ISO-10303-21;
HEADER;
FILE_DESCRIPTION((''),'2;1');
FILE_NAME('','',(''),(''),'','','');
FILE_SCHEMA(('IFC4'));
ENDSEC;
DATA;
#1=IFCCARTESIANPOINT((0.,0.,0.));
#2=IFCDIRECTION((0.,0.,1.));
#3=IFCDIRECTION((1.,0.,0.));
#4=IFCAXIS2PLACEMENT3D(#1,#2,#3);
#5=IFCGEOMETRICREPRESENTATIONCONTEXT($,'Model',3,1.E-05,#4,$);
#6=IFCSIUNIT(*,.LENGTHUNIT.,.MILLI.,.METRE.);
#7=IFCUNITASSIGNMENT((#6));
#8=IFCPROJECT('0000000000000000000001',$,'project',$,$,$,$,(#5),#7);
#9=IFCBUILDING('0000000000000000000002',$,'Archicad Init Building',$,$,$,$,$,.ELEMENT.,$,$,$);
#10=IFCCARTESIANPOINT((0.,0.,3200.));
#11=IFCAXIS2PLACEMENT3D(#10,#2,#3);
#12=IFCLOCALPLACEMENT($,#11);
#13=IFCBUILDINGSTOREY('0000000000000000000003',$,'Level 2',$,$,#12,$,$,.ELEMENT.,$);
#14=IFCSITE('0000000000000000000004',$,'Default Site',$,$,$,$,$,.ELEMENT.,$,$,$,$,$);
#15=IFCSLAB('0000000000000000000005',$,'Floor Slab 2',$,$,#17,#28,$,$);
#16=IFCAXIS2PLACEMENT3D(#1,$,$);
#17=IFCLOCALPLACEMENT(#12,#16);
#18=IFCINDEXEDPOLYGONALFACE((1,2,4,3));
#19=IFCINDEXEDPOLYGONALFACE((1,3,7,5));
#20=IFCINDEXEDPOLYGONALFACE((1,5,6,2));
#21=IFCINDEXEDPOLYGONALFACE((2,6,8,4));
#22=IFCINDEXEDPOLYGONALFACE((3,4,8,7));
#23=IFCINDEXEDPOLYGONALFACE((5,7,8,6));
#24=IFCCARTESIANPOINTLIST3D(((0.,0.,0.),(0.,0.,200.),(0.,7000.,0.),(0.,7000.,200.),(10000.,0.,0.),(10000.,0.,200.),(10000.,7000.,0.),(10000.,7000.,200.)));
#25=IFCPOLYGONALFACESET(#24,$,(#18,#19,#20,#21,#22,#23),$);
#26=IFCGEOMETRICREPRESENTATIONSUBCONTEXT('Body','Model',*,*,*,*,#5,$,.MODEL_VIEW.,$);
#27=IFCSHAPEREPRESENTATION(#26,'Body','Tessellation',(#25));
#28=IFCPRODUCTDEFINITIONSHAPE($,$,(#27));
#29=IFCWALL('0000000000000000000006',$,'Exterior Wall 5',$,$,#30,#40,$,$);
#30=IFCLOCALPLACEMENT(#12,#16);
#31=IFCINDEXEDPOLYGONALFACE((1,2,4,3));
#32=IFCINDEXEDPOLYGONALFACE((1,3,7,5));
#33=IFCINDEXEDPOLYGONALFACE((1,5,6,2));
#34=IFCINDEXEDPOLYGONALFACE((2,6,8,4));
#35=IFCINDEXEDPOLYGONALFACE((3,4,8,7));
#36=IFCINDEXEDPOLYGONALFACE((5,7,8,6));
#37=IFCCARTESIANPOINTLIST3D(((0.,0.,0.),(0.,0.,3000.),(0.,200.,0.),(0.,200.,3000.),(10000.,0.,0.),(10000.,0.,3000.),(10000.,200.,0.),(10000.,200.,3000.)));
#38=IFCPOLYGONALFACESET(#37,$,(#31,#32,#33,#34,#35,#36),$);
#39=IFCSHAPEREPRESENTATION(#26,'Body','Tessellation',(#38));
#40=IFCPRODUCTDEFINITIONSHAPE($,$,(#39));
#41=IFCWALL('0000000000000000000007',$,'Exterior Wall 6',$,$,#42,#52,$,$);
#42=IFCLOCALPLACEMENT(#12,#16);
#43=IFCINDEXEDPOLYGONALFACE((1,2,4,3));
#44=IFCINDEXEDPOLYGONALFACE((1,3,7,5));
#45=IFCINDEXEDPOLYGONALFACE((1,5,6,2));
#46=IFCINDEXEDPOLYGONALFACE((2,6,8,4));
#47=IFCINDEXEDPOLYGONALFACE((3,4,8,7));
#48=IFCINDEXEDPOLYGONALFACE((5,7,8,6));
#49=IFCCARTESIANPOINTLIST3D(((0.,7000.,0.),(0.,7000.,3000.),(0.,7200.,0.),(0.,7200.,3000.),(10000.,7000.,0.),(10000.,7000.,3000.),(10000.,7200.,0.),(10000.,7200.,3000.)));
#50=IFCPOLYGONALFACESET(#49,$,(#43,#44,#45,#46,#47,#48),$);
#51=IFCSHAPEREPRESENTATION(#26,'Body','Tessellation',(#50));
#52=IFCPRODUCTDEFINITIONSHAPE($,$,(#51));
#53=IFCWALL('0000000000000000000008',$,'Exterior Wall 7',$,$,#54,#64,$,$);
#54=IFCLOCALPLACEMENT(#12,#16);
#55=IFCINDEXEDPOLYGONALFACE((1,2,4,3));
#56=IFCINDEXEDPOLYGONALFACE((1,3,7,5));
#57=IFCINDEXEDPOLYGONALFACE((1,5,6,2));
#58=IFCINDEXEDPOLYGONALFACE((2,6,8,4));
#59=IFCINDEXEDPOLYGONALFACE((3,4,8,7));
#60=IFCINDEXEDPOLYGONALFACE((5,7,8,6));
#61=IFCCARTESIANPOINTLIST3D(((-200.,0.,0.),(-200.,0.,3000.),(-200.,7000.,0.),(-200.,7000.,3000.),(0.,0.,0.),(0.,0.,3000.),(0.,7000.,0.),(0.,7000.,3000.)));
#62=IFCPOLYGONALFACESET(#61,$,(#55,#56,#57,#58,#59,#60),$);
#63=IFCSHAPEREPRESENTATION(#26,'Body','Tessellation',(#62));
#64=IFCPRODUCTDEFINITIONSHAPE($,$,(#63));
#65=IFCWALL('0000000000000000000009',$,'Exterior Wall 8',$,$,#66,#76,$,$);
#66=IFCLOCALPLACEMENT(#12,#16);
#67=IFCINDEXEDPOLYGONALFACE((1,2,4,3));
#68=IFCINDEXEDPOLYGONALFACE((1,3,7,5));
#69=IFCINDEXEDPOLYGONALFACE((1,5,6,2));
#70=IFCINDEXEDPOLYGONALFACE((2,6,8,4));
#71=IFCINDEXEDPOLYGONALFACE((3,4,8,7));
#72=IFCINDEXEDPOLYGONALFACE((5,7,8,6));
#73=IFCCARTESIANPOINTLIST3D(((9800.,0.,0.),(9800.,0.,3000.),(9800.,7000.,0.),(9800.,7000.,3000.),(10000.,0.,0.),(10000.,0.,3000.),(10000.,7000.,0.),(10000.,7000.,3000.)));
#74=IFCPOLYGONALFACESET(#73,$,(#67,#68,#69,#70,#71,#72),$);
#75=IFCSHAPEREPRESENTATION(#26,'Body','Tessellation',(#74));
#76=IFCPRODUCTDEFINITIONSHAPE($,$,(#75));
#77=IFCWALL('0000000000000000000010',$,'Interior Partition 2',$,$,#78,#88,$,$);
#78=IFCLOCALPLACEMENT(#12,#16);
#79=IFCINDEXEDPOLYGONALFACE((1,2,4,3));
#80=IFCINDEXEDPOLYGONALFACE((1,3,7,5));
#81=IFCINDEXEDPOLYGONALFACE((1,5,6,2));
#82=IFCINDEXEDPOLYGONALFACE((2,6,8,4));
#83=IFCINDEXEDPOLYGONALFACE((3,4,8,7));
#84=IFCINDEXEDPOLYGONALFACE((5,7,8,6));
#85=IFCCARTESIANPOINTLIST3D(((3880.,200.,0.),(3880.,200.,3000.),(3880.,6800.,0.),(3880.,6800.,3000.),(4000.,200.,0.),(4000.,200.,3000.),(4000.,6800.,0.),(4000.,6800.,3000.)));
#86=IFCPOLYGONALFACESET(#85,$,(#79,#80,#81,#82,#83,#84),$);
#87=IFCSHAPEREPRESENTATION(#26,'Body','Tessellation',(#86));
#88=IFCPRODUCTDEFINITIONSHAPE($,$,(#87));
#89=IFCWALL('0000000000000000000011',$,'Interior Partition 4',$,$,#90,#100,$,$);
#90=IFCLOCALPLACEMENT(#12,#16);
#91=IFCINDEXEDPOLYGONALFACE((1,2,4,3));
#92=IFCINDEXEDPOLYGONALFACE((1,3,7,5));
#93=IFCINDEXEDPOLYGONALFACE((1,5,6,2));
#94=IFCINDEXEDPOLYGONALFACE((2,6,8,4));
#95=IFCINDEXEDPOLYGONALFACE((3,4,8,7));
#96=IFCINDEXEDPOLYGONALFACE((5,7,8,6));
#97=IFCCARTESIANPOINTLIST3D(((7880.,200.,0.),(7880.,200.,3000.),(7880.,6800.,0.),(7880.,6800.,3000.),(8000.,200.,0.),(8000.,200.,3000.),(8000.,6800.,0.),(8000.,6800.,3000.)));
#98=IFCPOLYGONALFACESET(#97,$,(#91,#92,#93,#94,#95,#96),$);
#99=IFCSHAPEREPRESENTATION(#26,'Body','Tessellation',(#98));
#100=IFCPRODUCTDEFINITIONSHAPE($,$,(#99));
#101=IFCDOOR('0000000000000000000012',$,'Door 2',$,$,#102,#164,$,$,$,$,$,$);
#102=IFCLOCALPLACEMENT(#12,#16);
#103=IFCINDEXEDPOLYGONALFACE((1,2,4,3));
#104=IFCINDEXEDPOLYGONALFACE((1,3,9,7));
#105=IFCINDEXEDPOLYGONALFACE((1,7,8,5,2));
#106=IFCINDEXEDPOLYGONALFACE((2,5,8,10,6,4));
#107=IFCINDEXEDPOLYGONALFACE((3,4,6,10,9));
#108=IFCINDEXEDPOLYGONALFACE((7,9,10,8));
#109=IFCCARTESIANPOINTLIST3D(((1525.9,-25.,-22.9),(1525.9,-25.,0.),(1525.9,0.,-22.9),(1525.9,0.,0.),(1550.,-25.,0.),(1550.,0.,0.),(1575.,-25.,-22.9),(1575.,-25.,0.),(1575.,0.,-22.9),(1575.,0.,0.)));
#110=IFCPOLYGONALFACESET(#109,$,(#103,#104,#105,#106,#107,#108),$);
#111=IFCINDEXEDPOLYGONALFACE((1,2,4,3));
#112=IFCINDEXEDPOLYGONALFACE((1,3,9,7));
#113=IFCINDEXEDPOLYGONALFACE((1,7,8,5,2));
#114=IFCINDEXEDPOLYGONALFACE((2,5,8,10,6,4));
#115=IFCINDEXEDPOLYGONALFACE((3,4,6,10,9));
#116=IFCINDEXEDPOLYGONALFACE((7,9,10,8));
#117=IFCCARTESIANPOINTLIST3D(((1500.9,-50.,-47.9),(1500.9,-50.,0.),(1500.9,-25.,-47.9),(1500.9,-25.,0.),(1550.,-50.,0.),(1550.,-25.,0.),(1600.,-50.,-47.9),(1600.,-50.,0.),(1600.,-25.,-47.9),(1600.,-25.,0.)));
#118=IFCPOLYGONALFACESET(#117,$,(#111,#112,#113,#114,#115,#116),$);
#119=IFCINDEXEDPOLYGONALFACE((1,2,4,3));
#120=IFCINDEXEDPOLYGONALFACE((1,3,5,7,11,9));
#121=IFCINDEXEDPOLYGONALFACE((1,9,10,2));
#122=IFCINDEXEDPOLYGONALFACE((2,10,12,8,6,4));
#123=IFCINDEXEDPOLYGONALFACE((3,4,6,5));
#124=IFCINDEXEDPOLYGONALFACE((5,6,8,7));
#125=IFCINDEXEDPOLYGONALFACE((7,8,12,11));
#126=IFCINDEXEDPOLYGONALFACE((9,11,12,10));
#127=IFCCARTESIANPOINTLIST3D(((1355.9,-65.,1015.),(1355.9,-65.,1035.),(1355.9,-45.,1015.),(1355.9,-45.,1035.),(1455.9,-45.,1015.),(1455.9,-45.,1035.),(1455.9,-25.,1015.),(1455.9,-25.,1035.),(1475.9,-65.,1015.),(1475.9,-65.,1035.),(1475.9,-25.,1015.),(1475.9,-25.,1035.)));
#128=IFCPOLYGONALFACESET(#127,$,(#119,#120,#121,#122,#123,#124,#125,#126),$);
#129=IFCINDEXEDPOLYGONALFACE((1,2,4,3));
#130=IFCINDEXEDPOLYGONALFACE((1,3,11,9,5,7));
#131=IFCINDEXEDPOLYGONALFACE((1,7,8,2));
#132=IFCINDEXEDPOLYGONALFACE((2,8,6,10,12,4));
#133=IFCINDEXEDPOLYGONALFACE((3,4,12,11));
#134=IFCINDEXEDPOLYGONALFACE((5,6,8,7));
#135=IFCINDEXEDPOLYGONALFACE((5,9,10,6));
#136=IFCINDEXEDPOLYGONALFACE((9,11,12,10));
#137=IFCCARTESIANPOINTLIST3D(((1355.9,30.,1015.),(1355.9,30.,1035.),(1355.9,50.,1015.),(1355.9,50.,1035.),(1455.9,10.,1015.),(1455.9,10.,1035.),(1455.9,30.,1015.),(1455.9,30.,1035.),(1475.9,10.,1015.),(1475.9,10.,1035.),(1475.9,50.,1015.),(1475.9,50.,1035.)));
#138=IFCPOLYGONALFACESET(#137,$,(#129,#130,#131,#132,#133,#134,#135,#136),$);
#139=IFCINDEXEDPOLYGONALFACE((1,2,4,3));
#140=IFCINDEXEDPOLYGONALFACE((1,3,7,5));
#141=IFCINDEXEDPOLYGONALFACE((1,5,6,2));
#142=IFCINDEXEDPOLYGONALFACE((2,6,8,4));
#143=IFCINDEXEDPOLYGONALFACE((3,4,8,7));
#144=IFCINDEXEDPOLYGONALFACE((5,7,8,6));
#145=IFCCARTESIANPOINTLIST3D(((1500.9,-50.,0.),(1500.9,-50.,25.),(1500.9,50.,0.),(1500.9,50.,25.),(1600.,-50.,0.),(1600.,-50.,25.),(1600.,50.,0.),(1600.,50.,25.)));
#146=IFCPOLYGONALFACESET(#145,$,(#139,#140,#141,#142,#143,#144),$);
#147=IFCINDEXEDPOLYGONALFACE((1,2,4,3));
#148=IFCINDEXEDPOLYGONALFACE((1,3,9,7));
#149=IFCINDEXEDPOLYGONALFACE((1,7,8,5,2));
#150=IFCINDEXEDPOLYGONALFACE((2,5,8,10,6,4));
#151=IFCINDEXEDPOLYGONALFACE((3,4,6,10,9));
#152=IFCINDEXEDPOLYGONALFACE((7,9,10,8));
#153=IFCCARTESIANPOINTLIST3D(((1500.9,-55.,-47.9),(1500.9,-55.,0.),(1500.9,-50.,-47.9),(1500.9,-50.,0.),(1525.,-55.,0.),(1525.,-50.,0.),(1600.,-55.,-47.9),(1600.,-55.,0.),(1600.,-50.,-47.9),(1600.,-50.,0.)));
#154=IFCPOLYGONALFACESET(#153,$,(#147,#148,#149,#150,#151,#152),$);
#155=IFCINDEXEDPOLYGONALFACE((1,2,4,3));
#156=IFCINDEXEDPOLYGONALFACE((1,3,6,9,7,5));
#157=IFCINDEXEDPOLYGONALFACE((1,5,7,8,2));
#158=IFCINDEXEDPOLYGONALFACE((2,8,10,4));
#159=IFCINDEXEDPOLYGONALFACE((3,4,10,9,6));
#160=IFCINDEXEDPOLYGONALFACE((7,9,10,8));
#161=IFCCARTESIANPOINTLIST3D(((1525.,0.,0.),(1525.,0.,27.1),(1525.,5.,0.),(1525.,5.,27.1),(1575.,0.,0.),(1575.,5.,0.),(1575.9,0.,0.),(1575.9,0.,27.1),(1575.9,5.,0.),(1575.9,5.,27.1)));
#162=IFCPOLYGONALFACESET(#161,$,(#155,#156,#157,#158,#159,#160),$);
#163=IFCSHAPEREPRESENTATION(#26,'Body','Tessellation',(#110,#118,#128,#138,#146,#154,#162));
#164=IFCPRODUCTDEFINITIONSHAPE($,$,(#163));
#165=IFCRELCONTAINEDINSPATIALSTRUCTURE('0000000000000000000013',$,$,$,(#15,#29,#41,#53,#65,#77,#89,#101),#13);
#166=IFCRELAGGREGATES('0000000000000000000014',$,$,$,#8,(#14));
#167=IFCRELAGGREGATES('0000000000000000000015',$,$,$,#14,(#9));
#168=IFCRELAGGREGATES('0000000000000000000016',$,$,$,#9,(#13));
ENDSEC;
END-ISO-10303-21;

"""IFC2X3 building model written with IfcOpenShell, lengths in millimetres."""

from ifc_helpers import new_model, si_unit, frame, origin_with_axes, place, context, subcontext, project, spatial, polyline, outline, extrude, element, save


model = new_model("IFC2X3")

# Units and contexts
model_context = context("Model", 3, precision=1e-05, world=origin_with_axes())
body_context = subcontext(model_context, "Body", "Model", "MODEL_VIEW")
ifc_project = project(units=[si_unit("LENGTHUNIT", "METRE", prefix="MILLI")], contexts=[model_context])

# Site, building, storey
site = spatial("IfcSite", under=ifc_project, Name="Default Site", CompositionType="ELEMENT")
building = spatial("IfcBuilding", under=site, Name="Archicad Init Building", CompositionType="ELEMENT")
storey_placement = place(None, frame((0.0, 0.0, 3200.0), z_axis=(0.0, 0.0, 1.0), x_axis=(1.0, 0.0, 0.0)))
storey = spatial("IfcBuildingStorey", under=building, at=storey_placement, Name="Level 2", CompositionType="ELEMENT")

# Slab
slab_placement = place(storey_placement, origin_with_axes())
element("IfcSlab", 1, at=slab_placement, inside=storey, Name="Floor Slab 2", context=body_context, shape_type="SweptSolid", body=[
    extrude(outline(polyline([(0.0, 0.0), (10000.0, 0.0), (10000.0, 7000.0), (0.0, 7000.0), (0.0, 0.0)])), origin_with_axes(), (0.0, 0.0, 1.0), 200.0),
])

# Walls
for number, where, z_axis, x_axis, name in (
    (2, (0.0, 0.0, 0.0), (0.0, 0.0, 1.0), (1.0, 0.0, 0.0), "Exterior Wall 5"),
    (3, (0.0, 7000.0, 0.0), (0.0, 0.0, 1.0), (1.0, 0.0, 0.0), "Exterior Wall 6"),
):
    element("IfcWall", number, at=place(storey_placement, frame(where, z_axis=z_axis, x_axis=x_axis)), inside=storey, Name=name, context=body_context, shape_type="SweptSolid", body=[
        extrude(outline(polyline([(0.0, 0.0), (0.0, 200.0), (10000.0, 200.0), (10000.0, 0.0), (0.0, 0.0)])), origin_with_axes(), (0.0, 0.0, 1.0), 3000.0),
    ])
for number, where, z_axis, x_axis, name in (
    (4, (0.0, 0.0, 0.0), (0.0, 0.0, 1.0), (0.0, 1.0, 0.0), "Exterior Wall 7"),
    (5, (10000.0, 0.0, 0.0), (0.0, 0.0, 1.0), (0.0, 1.0, 0.0), "Exterior Wall 8"),
):
    element("IfcWall", number, at=place(storey_placement, frame(where, z_axis=z_axis, x_axis=x_axis)), inside=storey, Name=name, context=body_context, shape_type="SweptSolid", body=[
        extrude(outline(polyline([(0.0, 0.0), (0.0, 200.0), (7000.0, 200.0), (7000.0, 0.0), (0.0, 0.0)])), origin_with_axes(), (0.0, 0.0, 1.0), 3000.0),
    ])
for number, where, z_axis, x_axis, name in (
    (6, (4000.0, 200.0, 0.0), (0.0, 0.0, 1.0), (0.0, 1.0, 0.0), "Interior Partition 2"),
    (7, (8000.0, 200.0, 0.0), (0.0, 0.0, 1.0), (0.0, 1.0, 0.0), "Interior Partition 4"),
):
    element("IfcWall", number, at=place(storey_placement, frame(where, z_axis=z_axis, x_axis=x_axis)), inside=storey, Name=name, context=body_context, shape_type="SweptSolid", body=[
        extrude(outline(polyline([(0.0, 0.0), (0.0, 120.0), (6600.0, 120.0), (6600.0, 0.0), (0.0, 0.0)])), origin_with_axes(), (0.0, 0.0, 1.0), 3000.0),
    ])

# Door
door_1_placement = place(storey_placement, frame((1550.0, -50.0, 0.0), z_axis=(0.0, 0.0, 1.0), x_axis=(1.0, 0.0, 0.0)))
element("IfcDoor", 8, at=door_1_placement, inside=storey, Name="Door 2", context=body_context, shape_type="SweptSolid", body=[
    extrude(outline(polyline([(0.0, 0.0), (0.0, 2.1), (0.9, 2.1), (0.9, 0.0), (-24.1, 0.0), (-24.1, -22.9), (25.0, -22.9), (25.0, 0.0), (0.0, 0.0)])), frame((0.0, 25.0, 0.0), z_axis=(0.0, -1.0, 0.0), x_axis=(1.0, 0.0, 0.0)), (0.0, 0.0, -1.0), 25.0),
    extrude(outline(polyline([(0.0, 0.0), (0.0, 2.1), (0.9, 2.1), (0.9, 0.0), (-49.1, 0.0), (-49.1, -47.9), (50.0, -47.9), (50.0, 0.0), (0.0, 0.0)])), frame((0.0, 0.0, 0.0), z_axis=(0.0, -1.0, 0.0), x_axis=(1.0, 0.0, 0.0)), (0.0, 0.0, -1.0), 25.0),
    extrude(outline(polyline([(0.0, 0.0), (-49.1, 0.0), (-49.1, 35.0), (0.0, 35.0), (0.0, 0.0)])), frame((25.0, 25.0, 25.0), z_axis=(0.0, 0.0, 1.0), x_axis=(1.0, 0.0, 0.0)), (0.0, 0.0, 1.0), -47.9),
    extrude(outline(polyline([(0.0, 0.0), (0.0, -40.0), (-120.0, -40.0), (-120.0, -20.0), (-20.0, -20.0), (-20.0, 0.0), (0.0, 0.0)])), frame((-74.1, 25.0, 1015.0), z_axis=(0.0, 0.0, 1.0), x_axis=(1.0, 0.0, 0.0)), (0.0, 0.0, 1.0), 20.0),
    extrude(outline(polyline([(0.0, 0.0), (0.0, 40.0), (-120.0, 40.0), (-120.0, 20.0), (-20.0, 20.0), (-20.0, 0.0), (0.0, 0.0)])), frame((-74.1, 60.0, 1015.0), z_axis=(0.0, 0.0, 1.0), x_axis=(1.0, 0.0, 0.0)), (0.0, 0.0, 1.0), 20.0),
    extrude(outline(polyline([(0.0, 0.0), (-99.1, 0.0), (-99.1, 100.0), (0.0, 100.0), (0.0, 0.0)])), frame((50.0, 0.0, 0.0), z_axis=(0.0, 0.0, 1.0), x_axis=(1.0, 0.0, 0.0)), (0.0, 0.0, 1.0), 25.0),
    extrude(outline(polyline([(0.0, 0.0), (0.0, 27.1), (50.9, 27.1), (50.9, 0.0), (-24.1, 0.0), (-24.1, -47.9), (75.0, -47.9), (75.0, 0.0), (0.0, 0.0)])), frame((-25.0, -5.0, 0.0), z_axis=(0.0, -1.0, 0.0), x_axis=(1.0, 0.0, 0.0)), (0.0, 0.0, -1.0), 5.0),
    extrude(outline(polyline([(0.0, 0.0), (0.0, 27.1), (50.9, 27.1), (50.9, 0.0), (0.9, 0.0), (0.9, -22.9), (50.0, -22.9), (50.0, 0.0), (0.0, 0.0)])), frame((-25.0, 50.0, 0.0), z_axis=(0.0, -1.0, 0.0), x_axis=(1.0, 0.0, 0.0)), (0.0, 0.0, -1.0), 5.0),
])

save(model, "model.ifc")
